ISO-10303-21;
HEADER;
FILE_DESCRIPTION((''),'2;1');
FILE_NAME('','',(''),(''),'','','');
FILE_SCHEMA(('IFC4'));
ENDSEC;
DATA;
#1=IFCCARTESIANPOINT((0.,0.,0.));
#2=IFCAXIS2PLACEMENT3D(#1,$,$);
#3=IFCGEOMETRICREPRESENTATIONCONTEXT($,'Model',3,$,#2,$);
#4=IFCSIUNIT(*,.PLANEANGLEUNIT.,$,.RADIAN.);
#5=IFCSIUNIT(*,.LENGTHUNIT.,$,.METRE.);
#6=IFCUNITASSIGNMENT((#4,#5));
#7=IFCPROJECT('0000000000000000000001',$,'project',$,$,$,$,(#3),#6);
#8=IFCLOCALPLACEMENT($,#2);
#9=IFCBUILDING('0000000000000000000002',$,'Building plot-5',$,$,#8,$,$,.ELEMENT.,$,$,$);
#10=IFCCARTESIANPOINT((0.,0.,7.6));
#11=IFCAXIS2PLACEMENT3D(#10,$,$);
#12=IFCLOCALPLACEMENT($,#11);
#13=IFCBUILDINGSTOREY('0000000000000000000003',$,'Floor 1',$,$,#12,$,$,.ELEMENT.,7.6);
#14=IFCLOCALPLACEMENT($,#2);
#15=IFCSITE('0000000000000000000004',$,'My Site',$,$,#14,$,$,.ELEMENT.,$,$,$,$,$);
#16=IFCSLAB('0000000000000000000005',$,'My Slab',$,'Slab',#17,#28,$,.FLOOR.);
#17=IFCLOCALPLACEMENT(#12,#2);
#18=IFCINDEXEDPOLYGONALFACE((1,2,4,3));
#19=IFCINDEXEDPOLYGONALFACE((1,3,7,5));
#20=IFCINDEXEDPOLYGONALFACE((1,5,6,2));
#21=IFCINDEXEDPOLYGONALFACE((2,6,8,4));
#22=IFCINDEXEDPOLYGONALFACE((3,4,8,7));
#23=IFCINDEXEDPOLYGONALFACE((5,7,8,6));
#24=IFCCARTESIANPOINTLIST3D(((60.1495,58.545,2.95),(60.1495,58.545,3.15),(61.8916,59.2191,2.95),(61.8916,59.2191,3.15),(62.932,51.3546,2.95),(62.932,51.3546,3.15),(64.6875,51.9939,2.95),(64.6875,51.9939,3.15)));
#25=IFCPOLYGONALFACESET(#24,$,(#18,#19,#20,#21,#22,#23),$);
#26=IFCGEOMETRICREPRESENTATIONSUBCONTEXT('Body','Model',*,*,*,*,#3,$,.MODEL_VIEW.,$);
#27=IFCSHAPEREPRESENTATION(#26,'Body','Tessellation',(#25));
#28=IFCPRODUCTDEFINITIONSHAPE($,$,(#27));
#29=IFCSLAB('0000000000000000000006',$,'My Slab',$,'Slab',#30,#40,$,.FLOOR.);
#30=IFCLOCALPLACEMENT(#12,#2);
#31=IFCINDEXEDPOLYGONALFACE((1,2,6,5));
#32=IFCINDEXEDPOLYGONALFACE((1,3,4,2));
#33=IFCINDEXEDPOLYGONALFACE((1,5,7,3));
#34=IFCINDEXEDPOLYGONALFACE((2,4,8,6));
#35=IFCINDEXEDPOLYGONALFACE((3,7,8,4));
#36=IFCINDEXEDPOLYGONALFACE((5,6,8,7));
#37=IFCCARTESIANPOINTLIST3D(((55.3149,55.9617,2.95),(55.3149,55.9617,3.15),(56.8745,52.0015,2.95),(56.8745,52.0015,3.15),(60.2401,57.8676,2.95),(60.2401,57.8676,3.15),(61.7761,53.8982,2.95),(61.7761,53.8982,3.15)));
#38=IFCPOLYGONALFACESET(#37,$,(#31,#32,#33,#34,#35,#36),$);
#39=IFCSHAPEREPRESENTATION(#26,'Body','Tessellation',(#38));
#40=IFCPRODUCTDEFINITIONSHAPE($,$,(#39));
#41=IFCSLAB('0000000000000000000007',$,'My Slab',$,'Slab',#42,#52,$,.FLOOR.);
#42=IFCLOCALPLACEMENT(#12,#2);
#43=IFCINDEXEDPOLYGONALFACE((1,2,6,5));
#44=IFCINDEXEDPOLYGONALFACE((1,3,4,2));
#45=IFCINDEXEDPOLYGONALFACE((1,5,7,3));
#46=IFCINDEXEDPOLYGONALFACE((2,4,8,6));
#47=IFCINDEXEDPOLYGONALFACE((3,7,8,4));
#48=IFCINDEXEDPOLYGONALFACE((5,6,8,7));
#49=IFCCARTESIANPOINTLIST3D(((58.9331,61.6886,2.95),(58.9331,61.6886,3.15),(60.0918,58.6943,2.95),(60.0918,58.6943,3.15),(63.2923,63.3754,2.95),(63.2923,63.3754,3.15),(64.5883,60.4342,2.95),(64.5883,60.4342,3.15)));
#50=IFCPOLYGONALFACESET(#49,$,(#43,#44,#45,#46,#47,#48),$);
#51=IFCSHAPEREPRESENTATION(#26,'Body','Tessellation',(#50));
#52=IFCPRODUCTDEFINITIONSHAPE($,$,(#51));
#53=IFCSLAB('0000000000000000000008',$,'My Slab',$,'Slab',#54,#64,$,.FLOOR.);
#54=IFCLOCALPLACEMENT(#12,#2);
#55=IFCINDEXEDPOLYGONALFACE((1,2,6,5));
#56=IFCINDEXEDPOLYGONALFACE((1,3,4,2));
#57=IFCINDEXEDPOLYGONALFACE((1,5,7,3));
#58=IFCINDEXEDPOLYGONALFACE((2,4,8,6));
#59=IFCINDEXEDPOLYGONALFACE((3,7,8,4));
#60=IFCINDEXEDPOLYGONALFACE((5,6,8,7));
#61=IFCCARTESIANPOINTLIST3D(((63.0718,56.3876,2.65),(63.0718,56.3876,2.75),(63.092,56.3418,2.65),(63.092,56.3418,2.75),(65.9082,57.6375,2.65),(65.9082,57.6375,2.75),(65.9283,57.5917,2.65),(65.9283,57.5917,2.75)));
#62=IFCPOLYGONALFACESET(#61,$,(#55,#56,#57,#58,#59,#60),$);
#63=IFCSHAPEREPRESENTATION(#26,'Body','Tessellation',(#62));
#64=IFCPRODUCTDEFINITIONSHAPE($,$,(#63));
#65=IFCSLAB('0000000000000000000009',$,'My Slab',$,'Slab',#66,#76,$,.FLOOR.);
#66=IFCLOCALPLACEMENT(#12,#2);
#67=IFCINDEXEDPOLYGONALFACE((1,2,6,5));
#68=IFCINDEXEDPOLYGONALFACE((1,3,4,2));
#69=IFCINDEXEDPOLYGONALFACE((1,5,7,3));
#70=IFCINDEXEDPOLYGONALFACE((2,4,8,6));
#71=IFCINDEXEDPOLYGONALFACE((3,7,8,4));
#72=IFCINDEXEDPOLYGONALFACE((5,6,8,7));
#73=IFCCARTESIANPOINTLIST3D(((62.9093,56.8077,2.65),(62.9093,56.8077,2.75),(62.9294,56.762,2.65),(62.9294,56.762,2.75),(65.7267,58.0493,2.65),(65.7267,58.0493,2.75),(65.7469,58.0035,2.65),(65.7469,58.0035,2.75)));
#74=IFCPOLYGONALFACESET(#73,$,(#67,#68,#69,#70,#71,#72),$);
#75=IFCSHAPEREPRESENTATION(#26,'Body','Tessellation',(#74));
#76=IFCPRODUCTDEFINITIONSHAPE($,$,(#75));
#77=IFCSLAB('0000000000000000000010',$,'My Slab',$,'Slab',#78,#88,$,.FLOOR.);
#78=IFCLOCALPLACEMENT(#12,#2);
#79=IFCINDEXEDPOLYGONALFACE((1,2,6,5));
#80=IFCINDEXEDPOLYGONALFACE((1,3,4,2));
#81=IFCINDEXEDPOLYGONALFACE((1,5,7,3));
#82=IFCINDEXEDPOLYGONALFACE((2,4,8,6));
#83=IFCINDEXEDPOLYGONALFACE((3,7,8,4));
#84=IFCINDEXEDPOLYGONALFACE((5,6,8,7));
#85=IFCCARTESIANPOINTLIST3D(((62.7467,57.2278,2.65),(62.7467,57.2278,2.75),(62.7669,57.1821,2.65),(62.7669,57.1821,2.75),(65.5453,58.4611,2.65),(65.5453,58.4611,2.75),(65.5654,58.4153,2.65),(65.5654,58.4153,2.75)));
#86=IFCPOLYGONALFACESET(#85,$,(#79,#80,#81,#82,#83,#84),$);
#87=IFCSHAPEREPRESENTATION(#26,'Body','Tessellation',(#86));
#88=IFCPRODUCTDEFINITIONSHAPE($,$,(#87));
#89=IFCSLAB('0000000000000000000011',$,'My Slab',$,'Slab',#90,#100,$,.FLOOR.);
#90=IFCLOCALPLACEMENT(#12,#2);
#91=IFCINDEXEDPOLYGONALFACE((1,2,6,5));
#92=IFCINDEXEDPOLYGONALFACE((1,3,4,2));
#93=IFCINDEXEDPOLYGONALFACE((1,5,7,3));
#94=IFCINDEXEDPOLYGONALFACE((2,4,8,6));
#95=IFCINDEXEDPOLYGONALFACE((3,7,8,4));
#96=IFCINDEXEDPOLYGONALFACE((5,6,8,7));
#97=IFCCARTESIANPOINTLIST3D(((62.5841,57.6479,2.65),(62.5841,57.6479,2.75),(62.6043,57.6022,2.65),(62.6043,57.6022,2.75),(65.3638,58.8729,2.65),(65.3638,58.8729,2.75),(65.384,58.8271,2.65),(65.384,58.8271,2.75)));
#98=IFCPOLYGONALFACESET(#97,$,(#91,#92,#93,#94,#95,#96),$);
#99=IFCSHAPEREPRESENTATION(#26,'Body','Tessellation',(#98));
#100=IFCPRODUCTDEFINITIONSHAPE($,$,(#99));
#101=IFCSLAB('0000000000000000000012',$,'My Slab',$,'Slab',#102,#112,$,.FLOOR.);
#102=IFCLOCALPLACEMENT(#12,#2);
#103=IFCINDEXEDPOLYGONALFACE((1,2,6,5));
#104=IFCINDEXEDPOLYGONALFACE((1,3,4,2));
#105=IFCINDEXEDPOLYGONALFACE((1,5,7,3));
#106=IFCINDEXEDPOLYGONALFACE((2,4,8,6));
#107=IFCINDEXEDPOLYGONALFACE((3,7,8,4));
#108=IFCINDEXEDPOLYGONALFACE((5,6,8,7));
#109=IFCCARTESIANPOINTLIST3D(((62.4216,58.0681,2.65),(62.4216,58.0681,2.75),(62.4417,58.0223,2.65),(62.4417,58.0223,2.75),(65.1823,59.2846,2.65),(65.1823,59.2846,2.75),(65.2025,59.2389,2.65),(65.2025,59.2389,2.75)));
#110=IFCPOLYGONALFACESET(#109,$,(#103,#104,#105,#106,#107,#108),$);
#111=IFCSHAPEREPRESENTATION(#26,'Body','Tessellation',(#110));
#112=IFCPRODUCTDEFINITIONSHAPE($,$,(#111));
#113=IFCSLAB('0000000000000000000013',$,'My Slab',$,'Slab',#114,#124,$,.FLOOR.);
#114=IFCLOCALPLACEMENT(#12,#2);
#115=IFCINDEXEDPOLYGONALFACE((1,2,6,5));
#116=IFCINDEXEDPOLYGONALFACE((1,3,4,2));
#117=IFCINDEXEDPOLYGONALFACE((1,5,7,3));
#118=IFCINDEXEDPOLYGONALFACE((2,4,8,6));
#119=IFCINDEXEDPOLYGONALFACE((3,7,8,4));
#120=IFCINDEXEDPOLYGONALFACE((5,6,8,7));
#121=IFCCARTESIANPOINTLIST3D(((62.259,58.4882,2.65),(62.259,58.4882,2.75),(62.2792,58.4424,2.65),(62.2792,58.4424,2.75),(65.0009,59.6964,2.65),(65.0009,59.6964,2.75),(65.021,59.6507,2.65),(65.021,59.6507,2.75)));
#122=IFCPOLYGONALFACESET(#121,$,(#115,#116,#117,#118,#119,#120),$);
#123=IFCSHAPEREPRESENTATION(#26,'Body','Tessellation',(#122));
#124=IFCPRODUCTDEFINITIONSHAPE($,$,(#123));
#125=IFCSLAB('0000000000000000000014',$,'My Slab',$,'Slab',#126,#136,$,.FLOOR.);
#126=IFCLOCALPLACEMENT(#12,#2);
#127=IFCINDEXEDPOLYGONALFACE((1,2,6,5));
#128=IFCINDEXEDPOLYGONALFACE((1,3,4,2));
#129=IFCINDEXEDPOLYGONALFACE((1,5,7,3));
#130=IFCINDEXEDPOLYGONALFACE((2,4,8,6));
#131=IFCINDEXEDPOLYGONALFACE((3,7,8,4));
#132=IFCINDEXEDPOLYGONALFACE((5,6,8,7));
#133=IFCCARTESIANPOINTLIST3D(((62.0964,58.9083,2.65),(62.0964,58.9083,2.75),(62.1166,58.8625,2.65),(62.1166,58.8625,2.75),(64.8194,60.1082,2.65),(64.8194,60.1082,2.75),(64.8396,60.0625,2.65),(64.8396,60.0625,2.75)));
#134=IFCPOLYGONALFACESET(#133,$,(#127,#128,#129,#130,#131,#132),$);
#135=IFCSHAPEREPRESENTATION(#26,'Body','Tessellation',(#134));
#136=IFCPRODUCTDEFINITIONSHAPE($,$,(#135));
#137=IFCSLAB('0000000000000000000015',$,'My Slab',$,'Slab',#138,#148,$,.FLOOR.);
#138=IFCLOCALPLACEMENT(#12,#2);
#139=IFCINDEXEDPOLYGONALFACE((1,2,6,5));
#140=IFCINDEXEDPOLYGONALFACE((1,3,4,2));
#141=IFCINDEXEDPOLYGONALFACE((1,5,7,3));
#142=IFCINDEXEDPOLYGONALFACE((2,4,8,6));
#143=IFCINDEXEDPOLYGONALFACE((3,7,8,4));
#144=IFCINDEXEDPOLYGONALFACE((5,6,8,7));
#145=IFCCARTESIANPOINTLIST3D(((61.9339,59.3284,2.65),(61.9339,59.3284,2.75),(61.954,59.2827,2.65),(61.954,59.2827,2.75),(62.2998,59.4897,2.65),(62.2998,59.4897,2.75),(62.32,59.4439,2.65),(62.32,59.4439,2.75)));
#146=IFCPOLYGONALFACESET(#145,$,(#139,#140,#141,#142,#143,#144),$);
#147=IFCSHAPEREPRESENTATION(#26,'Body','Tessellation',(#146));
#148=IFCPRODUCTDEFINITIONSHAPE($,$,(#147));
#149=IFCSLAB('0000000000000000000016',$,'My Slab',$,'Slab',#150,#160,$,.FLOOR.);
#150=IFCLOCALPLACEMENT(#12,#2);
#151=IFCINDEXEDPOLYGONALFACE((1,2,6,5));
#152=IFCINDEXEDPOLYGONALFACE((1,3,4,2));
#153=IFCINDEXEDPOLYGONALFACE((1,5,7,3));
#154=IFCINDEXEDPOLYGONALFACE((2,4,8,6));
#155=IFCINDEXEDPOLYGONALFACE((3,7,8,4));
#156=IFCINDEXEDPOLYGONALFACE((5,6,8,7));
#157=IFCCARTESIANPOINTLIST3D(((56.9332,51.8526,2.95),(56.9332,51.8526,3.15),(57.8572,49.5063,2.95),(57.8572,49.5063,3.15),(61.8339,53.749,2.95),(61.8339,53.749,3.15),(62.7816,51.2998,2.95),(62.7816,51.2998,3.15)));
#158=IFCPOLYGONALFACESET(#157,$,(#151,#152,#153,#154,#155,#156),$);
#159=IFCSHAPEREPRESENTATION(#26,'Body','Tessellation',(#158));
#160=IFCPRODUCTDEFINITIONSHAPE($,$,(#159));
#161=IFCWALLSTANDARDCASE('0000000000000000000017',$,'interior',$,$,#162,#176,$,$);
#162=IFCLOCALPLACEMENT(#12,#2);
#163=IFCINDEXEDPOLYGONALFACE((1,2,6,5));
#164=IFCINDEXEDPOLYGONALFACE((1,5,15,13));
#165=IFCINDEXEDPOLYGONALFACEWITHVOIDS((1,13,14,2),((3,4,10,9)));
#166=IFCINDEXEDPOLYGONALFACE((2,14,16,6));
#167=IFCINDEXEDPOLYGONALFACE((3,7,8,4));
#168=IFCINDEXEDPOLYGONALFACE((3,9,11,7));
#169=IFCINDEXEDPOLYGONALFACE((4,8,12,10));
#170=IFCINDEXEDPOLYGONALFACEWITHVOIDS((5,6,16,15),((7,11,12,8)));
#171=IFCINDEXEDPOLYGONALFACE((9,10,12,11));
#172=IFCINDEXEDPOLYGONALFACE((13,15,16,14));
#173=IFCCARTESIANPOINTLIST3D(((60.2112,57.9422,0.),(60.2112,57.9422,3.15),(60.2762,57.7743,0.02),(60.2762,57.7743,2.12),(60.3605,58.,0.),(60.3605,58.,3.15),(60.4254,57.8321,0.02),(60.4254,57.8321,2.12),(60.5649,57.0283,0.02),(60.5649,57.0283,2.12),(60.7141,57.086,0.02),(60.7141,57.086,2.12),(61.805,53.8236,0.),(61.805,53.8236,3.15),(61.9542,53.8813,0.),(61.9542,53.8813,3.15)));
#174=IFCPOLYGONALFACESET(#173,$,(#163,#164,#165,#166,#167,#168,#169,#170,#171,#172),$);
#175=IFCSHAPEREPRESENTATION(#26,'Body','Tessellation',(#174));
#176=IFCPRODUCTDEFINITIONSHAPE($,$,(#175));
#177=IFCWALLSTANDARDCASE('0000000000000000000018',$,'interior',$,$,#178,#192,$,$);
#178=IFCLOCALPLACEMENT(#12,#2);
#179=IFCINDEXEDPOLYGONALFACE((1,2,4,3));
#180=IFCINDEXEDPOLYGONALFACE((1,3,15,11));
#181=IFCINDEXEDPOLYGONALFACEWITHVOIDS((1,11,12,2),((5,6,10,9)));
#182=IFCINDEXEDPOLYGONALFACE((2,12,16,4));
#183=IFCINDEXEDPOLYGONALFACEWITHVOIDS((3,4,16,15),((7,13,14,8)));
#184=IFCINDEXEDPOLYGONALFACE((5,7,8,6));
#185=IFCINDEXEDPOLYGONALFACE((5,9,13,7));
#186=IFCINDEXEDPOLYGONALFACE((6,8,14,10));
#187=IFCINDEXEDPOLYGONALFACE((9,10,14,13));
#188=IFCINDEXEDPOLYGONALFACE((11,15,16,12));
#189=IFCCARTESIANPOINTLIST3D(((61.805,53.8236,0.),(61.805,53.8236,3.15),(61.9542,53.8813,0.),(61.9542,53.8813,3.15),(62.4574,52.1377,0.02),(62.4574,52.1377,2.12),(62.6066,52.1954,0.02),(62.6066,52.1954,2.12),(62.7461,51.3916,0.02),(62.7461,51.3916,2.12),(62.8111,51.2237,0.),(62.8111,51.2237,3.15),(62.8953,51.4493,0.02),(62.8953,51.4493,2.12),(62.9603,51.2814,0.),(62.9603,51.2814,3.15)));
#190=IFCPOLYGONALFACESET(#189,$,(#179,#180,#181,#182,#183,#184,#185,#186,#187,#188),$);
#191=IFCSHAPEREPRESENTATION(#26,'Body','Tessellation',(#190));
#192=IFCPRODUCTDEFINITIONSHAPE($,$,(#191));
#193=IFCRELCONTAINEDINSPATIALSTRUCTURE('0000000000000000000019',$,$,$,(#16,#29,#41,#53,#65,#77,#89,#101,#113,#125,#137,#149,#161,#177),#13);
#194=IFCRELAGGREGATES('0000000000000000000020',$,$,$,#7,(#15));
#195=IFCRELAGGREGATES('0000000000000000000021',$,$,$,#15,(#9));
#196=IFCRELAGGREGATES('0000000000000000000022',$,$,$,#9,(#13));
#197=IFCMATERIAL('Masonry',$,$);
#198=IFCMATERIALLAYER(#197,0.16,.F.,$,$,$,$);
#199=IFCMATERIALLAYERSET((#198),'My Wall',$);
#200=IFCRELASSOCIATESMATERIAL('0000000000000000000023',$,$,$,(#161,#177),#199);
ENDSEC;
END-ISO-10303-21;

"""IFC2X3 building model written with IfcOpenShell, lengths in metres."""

from ifc_helpers import new_model, si_unit, frame, origin, place, context, subcontext, project, spatial, polyline, outline, extrude, material, layer, layer_set, layer_usage, element, save


model = new_model("IFC2X3")

# Units and contexts
model_context = context("Model", 3, world=origin())
body_context = subcontext(model_context, "Body", "Model", "MODEL_VIEW")
ifc_project = project(units=[si_unit("PLANEANGLEUNIT", "RADIAN"), si_unit("LENGTHUNIT", "METRE")], contexts=[model_context])

# Site, building, storey
site_placement = place(None, origin())
site = spatial("IfcSite", under=ifc_project, at=site_placement, Name="My Site", CompositionType="ELEMENT")
building_placement = place(None, origin())
building = spatial("IfcBuilding", under=site, at=building_placement, Name="Building plot-5", CompositionType="ELEMENT")
storey_placement = place(None, frame((0.0, 0.0, 7.6)))
storey = spatial("IfcBuildingStorey", under=building, at=storey_placement, Name="Floor 1", CompositionType="ELEMENT", Elevation=7.6)

# Slabs
slab_1_placement = place(storey_placement, frame((0.0, 0.0, 2.95)))
element("IfcSlab", 1, at=slab_1_placement, inside=storey, Name="My Slab", ObjectType="Slab", PredefinedType="FLOOR", context=body_context, shape_type="SweptSolid", body=[
    extrude(outline(polyline([(61.8916, 59.2191), (60.1495, 58.545), (62.932, 51.3546), (64.6875, 51.9939), (61.8916, 59.2191)])), origin(), (0.0, 0.0, 1.0), 0.2),
])
slab_2_placement = place(storey_placement, frame((0.0, 0.0, 2.95)))
element("IfcSlab", 2, at=slab_2_placement, inside=storey, Name="My Slab", ObjectType="Slab", PredefinedType="FLOOR", context=body_context, shape_type="SweptSolid", body=[
    extrude(outline(polyline([(55.3149, 55.9617), (56.8745, 52.0015), (61.7761, 53.8982), (60.2401, 57.8676), (55.3149, 55.9617)])), origin(), (0.0, 0.0, 1.0), 0.2),
])
slab_3_placement = place(storey_placement, frame((0.0, 0.0, 2.95)))
element("IfcSlab", 3, at=slab_3_placement, inside=storey, Name="My Slab", ObjectType="Slab", PredefinedType="FLOOR", context=body_context, shape_type="SweptSolid", body=[
    extrude(outline(polyline([(58.9331, 61.6886), (60.0918, 58.6943), (64.5883, 60.4342), (63.2923, 63.3754), (58.9331, 61.6886)])), origin(), (0.0, 0.0, 1.0), 0.2),
])
slab_4_placement = place(storey_placement, frame((0.0, 0.0, 2.65)))
element("IfcSlab", 4, at=slab_4_placement, inside=storey, Name="My Slab", ObjectType="Slab", PredefinedType="FLOOR", context=body_context, shape_type="SweptSolid", body=[
    extrude(outline(polyline([(65.9283, 57.5917), (65.9082, 57.6375), (63.0718, 56.3876), (63.092, 56.3418), (65.9283, 57.5917)])), origin(), (0.0, 0.0, 1.0), 0.1),
])
slab_5_placement = place(storey_placement, frame((0.0, 0.0, 2.65)))
element("IfcSlab", 5, at=slab_5_placement, inside=storey, Name="My Slab", ObjectType="Slab", PredefinedType="FLOOR", context=body_context, shape_type="SweptSolid", body=[
    extrude(outline(polyline([(65.7469, 58.0035), (65.7267, 58.0493), (62.9093, 56.8077), (62.9294, 56.762), (65.7469, 58.0035)])), origin(), (0.0, 0.0, 1.0), 0.1),
])
slab_6_placement = place(storey_placement, frame((0.0, 0.0, 2.65)))
element("IfcSlab", 6, at=slab_6_placement, inside=storey, Name="My Slab", ObjectType="Slab", PredefinedType="FLOOR", context=body_context, shape_type="SweptSolid", body=[
    extrude(outline(polyline([(65.5654, 58.4153), (65.5453, 58.4611), (62.7467, 57.2278), (62.7669, 57.1821), (65.5654, 58.4153)])), origin(), (0.0, 0.0, 1.0), 0.1),
])
slab_7_placement = place(storey_placement, frame((0.0, 0.0, 2.65)))
element("IfcSlab", 7, at=slab_7_placement, inside=storey, Name="My Slab", ObjectType="Slab", PredefinedType="FLOOR", context=body_context, shape_type="SweptSolid", body=[
    extrude(outline(polyline([(65.384, 58.8271), (65.3638, 58.8729), (62.5841, 57.6479), (62.6043, 57.6022), (65.384, 58.8271)])), origin(), (0.0, 0.0, 1.0), 0.1),
])
slab_8_placement = place(storey_placement, frame((0.0, 0.0, 2.65)))
element("IfcSlab", 8, at=slab_8_placement, inside=storey, Name="My Slab", ObjectType="Slab", PredefinedType="FLOOR", context=body_context, shape_type="SweptSolid", body=[
    extrude(outline(polyline([(65.2025, 59.2389), (65.1823, 59.2846), (62.4216, 58.0681), (62.4417, 58.0223), (65.2025, 59.2389)])), origin(), (0.0, 0.0, 1.0), 0.1),
])
slab_9_placement = place(storey_placement, frame((0.0, 0.0, 2.65)))
element("IfcSlab", 9, at=slab_9_placement, inside=storey, Name="My Slab", ObjectType="Slab", PredefinedType="FLOOR", context=body_context, shape_type="SweptSolid", body=[
    extrude(outline(polyline([(65.021, 59.6507), (65.0009, 59.6964), (62.259, 58.4882), (62.2792, 58.4424), (65.021, 59.6507)])), origin(), (0.0, 0.0, 1.0), 0.1),
])
slab_10_placement = place(storey_placement, frame((0.0, 0.0, 2.65)))
element("IfcSlab", 10, at=slab_10_placement, inside=storey, Name="My Slab", ObjectType="Slab", PredefinedType="FLOOR", context=body_context, shape_type="SweptSolid", body=[
    extrude(outline(polyline([(64.8396, 60.0625), (64.8194, 60.1082), (62.0964, 58.9083), (62.1166, 58.8625), (64.8396, 60.0625)])), origin(), (0.0, 0.0, 1.0), 0.1),
])
slab_11_placement = place(storey_placement, frame((0.0, 0.0, 2.65)))
element("IfcSlab", 11, at=slab_11_placement, inside=storey, Name="My Slab", ObjectType="Slab", PredefinedType="FLOOR", context=body_context, shape_type="SweptSolid", body=[
    extrude(outline(polyline([(62.32, 59.4439), (62.2998, 59.4897), (61.9339, 59.3284), (61.954, 59.2827), (62.32, 59.4439)])), origin(), (0.0, 0.0, 1.0), 0.1),
])
slab_12_placement = place(storey_placement, frame((0.0, 0.0, 2.95)))
element("IfcSlab", 12, at=slab_12_placement, inside=storey, Name="My Slab", ObjectType="Slab", PredefinedType="FLOOR", context=body_context, shape_type="SweptSolid", body=[
    extrude(outline(polyline([(56.9332, 51.8526), (57.8572, 49.5063), (62.7816, 51.2998), (61.8339, 53.749), (56.9332, 51.8526)])), origin(), (0.0, 0.0, 1.0), 0.2),
])

# Walls, openings
ifc_material = material(Name="Masonry")
ifc_layer = layer(ifc_material, 0.16, ventilated=False)
ifc_layer_set = layer_set([ifc_layer], Name="My Wall")
ifc_layer_usage = layer_usage(ifc_layer_set, "AXIS2", "NEGATIVE", 0.08)
wall_1_placement = place(storey_placement, origin())
wall_1 = element("IfcWallStandardCase", 13, at=wall_1_placement, inside=storey, material=ifc_layer_usage, Name="interior", context=body_context, shape_type="SweptSolid", body=[
    extrude(outline(polyline([(60.3605, 58.0), (60.2112, 57.9422), (61.805, 53.8236), (61.9542, 53.8813), (60.3605, 58.0)])), origin(), (0.0, 0.0, 1.0), 3.15),
])
opening_1_placement = place(storey_placement, frame((0.0, 0.0, 0.02)))
element("IfcOpeningElement", 14, at=opening_1_placement, cuts=wall_1, ObjectType="Opening", context=body_context, shape_type="SweptSolid", body=[
    extrude(outline(polyline([(60.2762, 57.7743), (60.5649, 57.0283), (60.7141, 57.086), (60.4254, 57.8321), (60.2762, 57.7743)])), origin(), (0.0, 0.0, 1.0), 2.1),
])
wall_2_placement = place(storey_placement, origin())
wall_2 = element("IfcWallStandardCase", 15, at=wall_2_placement, inside=storey, material=ifc_layer_usage, Name="interior", context=body_context, shape_type="SweptSolid", body=[
    extrude(outline(polyline([(61.9542, 53.8813), (61.805, 53.8236), (62.8111, 51.2237), (62.9603, 51.2814), (61.9542, 53.8813)])), origin(), (0.0, 0.0, 1.0), 3.15),
])
opening_2_placement = place(storey_placement, frame((0.0, 0.0, 0.02)))
element("IfcOpeningElement", 16, at=opening_2_placement, cuts=wall_2, ObjectType="Opening", context=body_context, shape_type="SweptSolid", body=[
    extrude(outline(polyline([(62.4574, 52.1377), (62.7461, 51.3916), (62.8953, 51.4493), (62.6066, 52.1954), (62.4574, 52.1377)])), origin(), (0.0, 0.0, 1.0), 2.1),
])

save(model, "model.ifc")
